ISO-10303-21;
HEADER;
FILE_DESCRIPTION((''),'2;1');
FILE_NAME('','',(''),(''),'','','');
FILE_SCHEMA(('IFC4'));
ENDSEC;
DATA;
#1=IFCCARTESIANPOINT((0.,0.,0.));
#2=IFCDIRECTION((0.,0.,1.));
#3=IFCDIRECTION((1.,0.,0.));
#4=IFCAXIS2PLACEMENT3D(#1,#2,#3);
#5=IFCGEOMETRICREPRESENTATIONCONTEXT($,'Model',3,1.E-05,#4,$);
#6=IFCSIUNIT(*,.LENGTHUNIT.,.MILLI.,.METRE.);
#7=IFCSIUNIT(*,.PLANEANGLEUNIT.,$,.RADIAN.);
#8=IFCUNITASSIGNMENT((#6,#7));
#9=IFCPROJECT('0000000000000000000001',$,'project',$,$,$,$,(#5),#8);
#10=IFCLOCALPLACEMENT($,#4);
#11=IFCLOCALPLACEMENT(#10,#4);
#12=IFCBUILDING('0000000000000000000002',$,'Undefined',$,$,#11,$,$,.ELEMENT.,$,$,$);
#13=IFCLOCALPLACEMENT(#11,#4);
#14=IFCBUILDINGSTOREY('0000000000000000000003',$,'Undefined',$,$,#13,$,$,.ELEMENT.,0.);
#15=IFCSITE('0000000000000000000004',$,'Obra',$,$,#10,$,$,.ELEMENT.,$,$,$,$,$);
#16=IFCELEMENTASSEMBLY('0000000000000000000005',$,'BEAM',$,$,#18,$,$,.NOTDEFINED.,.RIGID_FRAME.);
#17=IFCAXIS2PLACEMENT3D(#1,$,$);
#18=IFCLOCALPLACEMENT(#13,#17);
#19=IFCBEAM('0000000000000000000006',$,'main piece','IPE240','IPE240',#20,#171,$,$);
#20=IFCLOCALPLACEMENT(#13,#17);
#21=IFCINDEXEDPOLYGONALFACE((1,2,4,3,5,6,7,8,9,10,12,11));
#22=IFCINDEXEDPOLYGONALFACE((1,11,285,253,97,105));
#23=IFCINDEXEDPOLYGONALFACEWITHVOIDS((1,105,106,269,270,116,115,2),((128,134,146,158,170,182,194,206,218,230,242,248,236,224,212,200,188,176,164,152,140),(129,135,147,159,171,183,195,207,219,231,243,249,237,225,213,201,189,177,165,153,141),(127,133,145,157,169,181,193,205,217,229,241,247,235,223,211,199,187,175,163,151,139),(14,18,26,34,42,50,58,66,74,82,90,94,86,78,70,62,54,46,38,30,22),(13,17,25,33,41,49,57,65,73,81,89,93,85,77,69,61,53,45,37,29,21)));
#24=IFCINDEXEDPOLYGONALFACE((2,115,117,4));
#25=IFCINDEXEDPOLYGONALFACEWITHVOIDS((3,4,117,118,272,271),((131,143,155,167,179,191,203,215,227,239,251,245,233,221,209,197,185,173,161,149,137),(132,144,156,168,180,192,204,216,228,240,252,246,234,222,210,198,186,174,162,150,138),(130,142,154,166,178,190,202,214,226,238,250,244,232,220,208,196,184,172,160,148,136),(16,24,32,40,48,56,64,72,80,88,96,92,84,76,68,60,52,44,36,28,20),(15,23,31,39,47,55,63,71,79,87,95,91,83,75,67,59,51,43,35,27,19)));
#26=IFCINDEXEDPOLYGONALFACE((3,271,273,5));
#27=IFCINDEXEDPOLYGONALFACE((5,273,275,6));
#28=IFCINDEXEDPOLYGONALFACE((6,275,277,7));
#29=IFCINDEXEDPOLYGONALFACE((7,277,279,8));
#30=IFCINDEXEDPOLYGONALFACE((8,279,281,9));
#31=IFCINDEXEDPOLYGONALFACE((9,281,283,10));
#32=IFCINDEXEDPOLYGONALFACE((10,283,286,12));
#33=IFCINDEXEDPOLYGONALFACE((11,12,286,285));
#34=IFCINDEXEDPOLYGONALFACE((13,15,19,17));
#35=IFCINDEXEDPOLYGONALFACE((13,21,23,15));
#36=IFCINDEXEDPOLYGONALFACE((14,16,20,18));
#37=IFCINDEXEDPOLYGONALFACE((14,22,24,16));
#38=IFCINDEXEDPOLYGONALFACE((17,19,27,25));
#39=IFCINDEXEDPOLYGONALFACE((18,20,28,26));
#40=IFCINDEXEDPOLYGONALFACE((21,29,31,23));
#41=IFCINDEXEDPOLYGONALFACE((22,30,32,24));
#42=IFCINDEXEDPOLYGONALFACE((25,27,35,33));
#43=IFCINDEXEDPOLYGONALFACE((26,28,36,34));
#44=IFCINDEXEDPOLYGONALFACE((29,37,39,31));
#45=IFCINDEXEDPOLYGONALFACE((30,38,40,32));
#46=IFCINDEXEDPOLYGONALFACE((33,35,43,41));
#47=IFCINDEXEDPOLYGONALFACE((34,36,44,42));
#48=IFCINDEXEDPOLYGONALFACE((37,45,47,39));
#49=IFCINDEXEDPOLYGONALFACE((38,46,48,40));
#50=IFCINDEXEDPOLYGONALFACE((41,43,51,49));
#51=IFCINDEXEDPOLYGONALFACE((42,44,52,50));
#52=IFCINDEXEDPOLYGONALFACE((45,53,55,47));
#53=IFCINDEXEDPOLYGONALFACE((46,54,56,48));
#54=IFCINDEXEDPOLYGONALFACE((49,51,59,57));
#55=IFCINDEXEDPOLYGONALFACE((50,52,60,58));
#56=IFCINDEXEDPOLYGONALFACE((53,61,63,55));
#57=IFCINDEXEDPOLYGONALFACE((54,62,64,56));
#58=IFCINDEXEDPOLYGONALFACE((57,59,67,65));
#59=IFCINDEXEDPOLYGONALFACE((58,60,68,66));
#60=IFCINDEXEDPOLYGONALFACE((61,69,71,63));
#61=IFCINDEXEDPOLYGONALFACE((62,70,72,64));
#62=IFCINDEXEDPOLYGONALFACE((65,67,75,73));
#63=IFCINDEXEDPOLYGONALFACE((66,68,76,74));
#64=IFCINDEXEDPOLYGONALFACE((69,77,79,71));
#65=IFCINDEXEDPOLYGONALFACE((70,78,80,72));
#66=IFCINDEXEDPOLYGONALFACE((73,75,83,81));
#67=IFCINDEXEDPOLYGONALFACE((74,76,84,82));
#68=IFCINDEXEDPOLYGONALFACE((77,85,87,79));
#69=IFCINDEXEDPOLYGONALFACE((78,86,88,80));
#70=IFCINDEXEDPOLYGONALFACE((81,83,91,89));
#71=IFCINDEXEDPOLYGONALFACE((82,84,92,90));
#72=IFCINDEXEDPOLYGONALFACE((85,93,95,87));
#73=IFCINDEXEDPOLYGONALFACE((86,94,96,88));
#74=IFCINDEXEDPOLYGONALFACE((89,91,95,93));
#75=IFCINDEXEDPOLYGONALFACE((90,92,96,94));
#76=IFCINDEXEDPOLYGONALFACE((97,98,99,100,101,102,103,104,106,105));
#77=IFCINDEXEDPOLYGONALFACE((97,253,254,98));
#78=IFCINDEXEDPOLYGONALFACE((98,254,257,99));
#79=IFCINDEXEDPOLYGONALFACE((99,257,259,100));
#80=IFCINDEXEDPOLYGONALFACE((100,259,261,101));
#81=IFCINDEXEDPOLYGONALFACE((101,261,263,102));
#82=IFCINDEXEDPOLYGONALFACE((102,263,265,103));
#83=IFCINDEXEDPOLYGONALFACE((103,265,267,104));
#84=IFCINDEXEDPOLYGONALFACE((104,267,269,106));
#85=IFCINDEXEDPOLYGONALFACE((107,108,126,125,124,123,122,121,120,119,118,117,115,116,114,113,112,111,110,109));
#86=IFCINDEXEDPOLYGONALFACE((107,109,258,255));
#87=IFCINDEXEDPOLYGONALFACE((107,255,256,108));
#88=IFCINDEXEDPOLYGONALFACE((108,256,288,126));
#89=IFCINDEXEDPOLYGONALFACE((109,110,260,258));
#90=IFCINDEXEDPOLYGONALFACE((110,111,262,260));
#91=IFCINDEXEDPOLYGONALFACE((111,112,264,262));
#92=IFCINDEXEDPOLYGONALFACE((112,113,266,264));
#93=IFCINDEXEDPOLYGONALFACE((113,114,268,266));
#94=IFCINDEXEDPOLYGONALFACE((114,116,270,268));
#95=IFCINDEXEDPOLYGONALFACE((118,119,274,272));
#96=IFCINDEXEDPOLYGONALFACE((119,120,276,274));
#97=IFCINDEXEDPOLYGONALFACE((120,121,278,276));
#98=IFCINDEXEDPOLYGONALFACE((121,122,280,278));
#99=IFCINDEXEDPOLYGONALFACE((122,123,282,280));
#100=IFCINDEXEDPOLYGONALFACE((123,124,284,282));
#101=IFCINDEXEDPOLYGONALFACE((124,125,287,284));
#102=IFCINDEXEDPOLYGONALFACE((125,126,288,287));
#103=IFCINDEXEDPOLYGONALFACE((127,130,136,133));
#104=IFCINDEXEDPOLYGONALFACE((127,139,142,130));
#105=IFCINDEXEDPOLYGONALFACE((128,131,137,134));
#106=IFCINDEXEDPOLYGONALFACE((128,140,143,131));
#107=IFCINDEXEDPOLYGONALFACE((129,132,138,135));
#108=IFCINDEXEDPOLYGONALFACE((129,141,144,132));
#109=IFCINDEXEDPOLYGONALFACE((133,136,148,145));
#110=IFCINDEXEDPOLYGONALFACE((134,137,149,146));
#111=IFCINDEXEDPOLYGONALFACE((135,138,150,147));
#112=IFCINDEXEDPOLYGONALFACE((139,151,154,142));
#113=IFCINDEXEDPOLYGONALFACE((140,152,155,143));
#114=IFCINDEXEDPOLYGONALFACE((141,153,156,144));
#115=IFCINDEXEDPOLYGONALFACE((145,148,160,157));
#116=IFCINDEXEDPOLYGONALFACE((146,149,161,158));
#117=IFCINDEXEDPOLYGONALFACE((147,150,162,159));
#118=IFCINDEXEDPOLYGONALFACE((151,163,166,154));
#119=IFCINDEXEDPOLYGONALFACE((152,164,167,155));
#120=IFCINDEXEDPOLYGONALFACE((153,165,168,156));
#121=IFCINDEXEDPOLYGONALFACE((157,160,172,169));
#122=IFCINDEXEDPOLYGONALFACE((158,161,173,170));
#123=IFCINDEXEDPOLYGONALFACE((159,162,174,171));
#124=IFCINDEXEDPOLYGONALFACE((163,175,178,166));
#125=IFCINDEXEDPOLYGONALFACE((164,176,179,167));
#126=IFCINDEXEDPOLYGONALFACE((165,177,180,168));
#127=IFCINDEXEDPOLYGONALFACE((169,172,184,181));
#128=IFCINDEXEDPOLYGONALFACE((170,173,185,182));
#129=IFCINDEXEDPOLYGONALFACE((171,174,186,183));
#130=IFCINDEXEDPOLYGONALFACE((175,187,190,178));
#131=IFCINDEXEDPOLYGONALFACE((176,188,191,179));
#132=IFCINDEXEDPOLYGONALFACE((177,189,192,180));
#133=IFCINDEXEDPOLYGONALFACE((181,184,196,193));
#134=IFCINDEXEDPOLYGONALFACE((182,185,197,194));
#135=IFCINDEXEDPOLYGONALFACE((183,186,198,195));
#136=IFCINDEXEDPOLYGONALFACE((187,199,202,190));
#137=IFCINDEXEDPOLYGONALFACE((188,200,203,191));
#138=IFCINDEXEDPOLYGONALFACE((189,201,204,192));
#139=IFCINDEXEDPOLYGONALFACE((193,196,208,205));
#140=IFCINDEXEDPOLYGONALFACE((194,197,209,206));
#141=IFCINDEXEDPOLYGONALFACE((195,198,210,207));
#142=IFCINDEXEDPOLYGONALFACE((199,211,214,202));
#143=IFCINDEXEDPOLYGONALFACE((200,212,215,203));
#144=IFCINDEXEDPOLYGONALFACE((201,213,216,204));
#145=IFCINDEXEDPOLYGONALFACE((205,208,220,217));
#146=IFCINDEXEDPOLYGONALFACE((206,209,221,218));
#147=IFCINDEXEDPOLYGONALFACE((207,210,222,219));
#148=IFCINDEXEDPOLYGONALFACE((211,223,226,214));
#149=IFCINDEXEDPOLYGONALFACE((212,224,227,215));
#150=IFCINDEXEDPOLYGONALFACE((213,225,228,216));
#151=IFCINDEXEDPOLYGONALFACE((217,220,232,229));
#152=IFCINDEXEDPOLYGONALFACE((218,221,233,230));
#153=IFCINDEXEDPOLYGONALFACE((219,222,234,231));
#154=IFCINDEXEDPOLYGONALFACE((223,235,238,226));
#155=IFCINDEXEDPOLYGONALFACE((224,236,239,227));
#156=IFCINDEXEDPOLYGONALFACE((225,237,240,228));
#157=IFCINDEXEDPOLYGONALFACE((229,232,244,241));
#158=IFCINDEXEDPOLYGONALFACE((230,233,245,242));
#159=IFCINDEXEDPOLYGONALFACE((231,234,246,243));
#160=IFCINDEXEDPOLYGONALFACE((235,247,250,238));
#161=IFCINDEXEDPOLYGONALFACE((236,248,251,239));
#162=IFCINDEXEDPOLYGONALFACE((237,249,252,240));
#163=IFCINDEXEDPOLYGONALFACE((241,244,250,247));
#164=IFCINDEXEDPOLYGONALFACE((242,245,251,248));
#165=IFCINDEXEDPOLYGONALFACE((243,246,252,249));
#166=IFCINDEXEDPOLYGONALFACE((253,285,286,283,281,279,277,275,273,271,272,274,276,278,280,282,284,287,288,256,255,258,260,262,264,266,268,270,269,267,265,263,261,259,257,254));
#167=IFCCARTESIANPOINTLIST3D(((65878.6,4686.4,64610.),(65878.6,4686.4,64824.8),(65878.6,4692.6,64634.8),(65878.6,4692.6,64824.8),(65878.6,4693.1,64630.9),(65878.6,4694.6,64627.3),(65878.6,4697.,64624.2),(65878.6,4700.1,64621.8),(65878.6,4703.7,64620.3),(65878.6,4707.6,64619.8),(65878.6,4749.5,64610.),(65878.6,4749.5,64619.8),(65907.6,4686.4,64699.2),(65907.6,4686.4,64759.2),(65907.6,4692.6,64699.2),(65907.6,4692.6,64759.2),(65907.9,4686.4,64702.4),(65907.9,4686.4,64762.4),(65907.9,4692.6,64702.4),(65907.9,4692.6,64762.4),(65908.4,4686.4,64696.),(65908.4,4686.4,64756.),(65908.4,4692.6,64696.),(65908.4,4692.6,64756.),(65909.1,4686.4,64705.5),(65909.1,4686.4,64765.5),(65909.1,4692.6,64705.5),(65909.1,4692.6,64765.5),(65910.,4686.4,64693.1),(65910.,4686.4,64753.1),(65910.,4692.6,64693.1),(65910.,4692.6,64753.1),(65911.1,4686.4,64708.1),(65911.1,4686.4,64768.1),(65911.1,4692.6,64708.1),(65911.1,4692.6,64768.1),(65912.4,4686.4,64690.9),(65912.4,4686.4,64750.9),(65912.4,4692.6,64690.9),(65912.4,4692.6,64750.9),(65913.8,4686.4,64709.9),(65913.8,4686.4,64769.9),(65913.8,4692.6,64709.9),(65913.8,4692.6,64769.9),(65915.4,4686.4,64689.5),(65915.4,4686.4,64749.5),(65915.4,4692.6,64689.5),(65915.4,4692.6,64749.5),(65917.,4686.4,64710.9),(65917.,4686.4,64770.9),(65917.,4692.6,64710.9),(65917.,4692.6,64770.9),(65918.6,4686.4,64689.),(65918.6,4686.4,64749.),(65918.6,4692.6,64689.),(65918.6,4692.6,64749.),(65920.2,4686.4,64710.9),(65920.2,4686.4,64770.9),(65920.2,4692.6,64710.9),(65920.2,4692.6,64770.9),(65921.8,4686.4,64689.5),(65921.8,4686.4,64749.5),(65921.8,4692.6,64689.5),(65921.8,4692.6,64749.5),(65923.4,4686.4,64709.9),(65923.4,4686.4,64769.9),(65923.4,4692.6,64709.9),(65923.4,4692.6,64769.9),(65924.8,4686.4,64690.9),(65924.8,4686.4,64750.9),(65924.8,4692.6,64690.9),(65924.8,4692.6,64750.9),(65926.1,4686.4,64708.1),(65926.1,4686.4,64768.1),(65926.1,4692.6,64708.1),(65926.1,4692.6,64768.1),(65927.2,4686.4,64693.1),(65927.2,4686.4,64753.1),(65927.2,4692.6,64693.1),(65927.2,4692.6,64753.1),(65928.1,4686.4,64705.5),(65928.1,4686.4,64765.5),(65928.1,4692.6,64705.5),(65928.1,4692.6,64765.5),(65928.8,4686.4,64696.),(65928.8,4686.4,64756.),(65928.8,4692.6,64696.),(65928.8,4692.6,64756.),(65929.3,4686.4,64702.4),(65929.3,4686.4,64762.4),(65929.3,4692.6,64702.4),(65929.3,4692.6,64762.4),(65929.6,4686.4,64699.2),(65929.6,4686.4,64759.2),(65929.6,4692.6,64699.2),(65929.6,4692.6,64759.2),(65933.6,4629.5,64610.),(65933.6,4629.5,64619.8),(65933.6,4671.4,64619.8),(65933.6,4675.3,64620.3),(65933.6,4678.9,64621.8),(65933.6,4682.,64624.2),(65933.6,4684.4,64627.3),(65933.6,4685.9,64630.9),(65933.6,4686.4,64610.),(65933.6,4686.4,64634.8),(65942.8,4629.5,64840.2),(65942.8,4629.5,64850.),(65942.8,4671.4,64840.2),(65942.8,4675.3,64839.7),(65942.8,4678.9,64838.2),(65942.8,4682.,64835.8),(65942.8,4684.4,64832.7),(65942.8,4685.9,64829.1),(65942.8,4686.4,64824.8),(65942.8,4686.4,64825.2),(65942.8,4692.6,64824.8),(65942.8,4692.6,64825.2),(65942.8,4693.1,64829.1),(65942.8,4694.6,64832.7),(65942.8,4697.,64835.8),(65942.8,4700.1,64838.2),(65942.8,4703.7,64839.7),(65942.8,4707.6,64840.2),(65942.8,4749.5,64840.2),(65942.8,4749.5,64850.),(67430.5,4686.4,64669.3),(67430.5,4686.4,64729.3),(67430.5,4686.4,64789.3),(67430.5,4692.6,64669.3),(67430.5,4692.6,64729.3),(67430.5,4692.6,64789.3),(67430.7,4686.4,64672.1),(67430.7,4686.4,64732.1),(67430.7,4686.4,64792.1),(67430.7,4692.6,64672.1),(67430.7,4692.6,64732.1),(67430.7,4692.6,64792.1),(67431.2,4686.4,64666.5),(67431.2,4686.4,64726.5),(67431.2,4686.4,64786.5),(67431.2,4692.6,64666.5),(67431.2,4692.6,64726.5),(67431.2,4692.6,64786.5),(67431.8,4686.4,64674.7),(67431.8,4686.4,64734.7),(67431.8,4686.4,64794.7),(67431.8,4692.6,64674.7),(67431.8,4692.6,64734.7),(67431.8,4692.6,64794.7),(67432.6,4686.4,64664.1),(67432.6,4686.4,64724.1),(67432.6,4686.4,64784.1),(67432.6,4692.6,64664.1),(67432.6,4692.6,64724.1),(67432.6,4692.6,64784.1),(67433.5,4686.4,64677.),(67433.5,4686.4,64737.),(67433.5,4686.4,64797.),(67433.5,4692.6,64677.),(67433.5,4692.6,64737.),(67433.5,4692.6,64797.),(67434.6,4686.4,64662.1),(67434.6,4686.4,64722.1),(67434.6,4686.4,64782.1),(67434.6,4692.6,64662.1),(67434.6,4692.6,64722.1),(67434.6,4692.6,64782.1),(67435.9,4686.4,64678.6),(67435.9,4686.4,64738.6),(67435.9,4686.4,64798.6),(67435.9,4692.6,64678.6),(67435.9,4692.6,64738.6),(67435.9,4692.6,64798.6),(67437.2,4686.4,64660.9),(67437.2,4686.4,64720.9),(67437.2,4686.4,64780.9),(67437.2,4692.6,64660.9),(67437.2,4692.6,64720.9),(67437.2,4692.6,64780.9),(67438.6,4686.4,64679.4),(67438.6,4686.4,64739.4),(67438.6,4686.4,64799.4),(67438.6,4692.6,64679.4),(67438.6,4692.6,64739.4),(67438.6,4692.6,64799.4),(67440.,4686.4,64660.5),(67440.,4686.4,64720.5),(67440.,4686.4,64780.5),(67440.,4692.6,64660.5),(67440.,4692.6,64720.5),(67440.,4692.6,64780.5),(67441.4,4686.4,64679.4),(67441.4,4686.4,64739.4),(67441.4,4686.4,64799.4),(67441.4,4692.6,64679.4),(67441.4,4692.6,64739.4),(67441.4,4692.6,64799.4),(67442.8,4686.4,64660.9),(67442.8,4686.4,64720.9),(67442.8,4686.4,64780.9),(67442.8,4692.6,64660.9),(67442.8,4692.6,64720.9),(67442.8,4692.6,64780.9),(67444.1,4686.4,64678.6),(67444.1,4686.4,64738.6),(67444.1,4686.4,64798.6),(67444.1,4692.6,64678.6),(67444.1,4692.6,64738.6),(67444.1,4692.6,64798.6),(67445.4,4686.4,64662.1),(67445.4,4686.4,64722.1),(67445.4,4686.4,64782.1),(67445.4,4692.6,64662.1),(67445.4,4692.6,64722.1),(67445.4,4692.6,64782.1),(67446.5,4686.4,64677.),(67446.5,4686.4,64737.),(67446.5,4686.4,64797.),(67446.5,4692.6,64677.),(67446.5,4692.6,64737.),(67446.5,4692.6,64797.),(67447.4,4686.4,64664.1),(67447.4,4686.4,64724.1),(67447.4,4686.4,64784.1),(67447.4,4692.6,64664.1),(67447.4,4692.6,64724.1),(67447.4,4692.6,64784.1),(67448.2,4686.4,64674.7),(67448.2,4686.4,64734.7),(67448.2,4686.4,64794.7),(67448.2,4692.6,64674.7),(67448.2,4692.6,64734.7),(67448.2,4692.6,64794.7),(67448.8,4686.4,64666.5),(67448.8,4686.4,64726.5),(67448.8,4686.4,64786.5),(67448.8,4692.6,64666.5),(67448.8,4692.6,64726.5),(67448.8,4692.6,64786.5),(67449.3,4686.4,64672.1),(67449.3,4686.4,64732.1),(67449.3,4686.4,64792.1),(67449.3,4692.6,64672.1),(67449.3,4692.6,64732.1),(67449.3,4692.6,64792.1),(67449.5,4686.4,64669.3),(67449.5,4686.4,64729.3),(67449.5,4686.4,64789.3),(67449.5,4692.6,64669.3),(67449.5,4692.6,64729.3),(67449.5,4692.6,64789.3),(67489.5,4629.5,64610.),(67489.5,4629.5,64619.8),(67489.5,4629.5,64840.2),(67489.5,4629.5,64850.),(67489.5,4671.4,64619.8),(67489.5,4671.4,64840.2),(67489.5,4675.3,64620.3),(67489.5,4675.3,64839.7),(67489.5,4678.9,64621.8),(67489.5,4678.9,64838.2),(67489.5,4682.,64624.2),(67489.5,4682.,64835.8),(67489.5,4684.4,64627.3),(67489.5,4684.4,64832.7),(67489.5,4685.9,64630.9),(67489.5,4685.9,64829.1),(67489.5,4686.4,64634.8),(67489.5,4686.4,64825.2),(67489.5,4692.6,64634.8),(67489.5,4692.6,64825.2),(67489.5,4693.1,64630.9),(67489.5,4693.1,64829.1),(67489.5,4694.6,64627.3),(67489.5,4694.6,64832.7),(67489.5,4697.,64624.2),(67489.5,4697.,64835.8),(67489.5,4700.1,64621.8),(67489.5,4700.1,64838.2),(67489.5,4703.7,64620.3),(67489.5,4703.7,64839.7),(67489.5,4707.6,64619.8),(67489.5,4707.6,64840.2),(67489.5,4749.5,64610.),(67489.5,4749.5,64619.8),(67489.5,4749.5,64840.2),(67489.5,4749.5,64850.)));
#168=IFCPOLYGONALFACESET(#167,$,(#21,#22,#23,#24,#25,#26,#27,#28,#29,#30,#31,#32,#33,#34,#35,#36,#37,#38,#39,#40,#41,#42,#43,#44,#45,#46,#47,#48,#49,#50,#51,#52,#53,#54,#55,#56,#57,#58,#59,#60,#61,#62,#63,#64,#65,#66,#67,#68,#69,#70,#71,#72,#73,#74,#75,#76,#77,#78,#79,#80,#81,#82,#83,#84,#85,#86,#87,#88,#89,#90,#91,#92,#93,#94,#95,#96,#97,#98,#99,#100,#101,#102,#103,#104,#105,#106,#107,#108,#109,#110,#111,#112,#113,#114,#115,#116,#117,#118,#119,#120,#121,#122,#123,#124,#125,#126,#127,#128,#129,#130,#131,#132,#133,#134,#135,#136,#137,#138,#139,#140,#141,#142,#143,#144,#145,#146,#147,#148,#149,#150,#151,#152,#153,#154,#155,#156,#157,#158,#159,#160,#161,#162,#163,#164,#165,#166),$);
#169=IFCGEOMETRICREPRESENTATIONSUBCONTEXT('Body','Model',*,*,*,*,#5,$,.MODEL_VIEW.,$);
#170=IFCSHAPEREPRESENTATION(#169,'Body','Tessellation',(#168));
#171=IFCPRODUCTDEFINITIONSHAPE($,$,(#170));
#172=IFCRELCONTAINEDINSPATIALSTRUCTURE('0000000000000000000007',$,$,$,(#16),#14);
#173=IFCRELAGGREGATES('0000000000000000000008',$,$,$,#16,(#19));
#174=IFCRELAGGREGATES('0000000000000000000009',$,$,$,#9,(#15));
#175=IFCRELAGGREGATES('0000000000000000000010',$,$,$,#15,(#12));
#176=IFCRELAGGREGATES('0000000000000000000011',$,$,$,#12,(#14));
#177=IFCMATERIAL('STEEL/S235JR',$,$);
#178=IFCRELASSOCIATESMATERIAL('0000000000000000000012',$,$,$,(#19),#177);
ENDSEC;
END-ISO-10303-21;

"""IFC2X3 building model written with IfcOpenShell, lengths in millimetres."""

from ifc_helpers import new_model, si_unit, frame, origin_with_axes, origin_2d_with_axis, place, context, subcontext, project, spatial, rectangle, circle, i_section, extrude, clip, halfspace, source, transform, mapped, material, element, aggregate, save


model = new_model("IFC2X3")

# Units and contexts
model_context = context("Model", 3, precision=1e-05, world=origin_with_axes())
body_context = subcontext(model_context, "Body", "Model", "MODEL_VIEW")
ifc_project = project(units=[si_unit("LENGTHUNIT", "METRE", prefix="MILLI"), si_unit("PLANEANGLEUNIT", "RADIAN")], contexts=[model_context])

# Site, building, storey
site_placement = place(None, origin_with_axes())
site = spatial("IfcSite", under=ifc_project, at=site_placement, Name="Obra", CompositionType="ELEMENT")
building_placement = place(site_placement, origin_with_axes())
building = spatial("IfcBuilding", under=site, at=building_placement, Name="Undefined", CompositionType="ELEMENT")
storey_placement = place(building_placement, origin_with_axes())
storey = spatial("IfcBuildingStorey", under=building, at=storey_placement, Name="Undefined", CompositionType="ELEMENT", Elevation=0.0)

# Element assembly, beam, openings
assembly_1_placement = place(storey_placement, origin_with_axes())
assembly_1 = element("IfcElementAssembly", 1, at=assembly_1_placement, inside=storey, Name="BEAM", AssemblyPlace="NOTDEFINED", PredefinedType="RIGID_FRAME")
ifc_material = material(Name="STEEL/S235JR")
beam_1_placement = place(assembly_1_placement, frame((65952.4, 4689.5, 64730.0), z_axis=(0.0, 0.0, 1.0), x_axis=(1.0, 0.0, 0.0)))
beam_1 = element("IfcBeam", 2, at=beam_1_placement, material=ifc_material, Name="main piece", Description="IPE240", ObjectType="IPE240", context=body_context, shape_type="Clipping", body=[
    clip(clip(extrude(i_section(OverallWidth=120.0, OverallDepth=240.0, WebThickness=6.2, FlangeThickness=9.8, FilletRadius=15.0, at=origin_2d_with_axis()), frame((1754.5, 0.0, 0.0), z_axis=(-1.0, 0.0, 0.0), x_axis=(0.0, -1.0, 0.0)), (0.0, 0.0, 1.0), 1828.3), halfspace(frame((1537.1, -60.0, -120.0), z_axis=(1.0, 0.000019, 0.0), x_axis=(0.0, 0.0, 1.0)), False)), halfspace(frame((-73.8, 0.0, -220.0), z_axis=(1.0, 0.0, 0.0), x_axis=(0.0, -1.0, 0.0)), True)),
])
opening_1_placement = place(assembly_1_placement, frame((65952.4, 4689.5, 64730.0), z_axis=(0.0, 0.0, 1.0), x_axis=(1.0, 0.0, 0.0)))
element("IfcOpeningElement", 3, at=opening_1_placement, cuts=beam_1, ObjectType="Recess", context=body_context, shape_type="SweptSolid", body=[
    extrude(rectangle(XDim=65.0, YDim=300.0, at=origin_2d_with_axis()), frame((-51.3, -153.1, 109.8), z_axis=(0.0, 0.0, -1.0), x_axis=(1.0, 0.0, 0.0)), (0.0, 0.0, 1.0), 249.6),
])
opening_2_placement = place(assembly_1_placement, frame((65952.4, 4689.5, 64730.0), z_axis=(0.0, 0.0, 1.0), x_axis=(1.0, 0.0, 0.0)))
element("IfcOpeningElement", 4, at=opening_2_placement, cuts=beam_1, ObjectType="Recess", context=body_context, shape_type="SweptSolid", body=[
    extrude(rectangle(XDim=26.2, YDim=76.2, at=origin_2d_with_axis()), frame((-47.7, -61.0, 107.9), z_axis=(0.0, 1.0, 0.0), x_axis=(0.0, 0.0, -1.0)), (0.0, 0.0, 1.0), 122.0),
])
shared_shape_1 = source(origin_with_axes(), body_context, "Body", "SweptSolid", [
    extrude(circle(Radius=11.0, at=origin_2d_with_axis()), frame((0.0, -3.2, 0.0), z_axis=(0.0, 1.0, 0.0), x_axis=(1.0, 0.0, 0.0)), (0.0, 0.0, 1.0), 6.4),
])
opening_3_placement = place(assembly_1_placement, frame((65878.6, 4689.5, 64850.0), z_axis=(1.0, 0.0, 0.0), x_axis=(0.0, 0.0, -1.0)))
element("IfcOpeningElement", 5, at=opening_3_placement, cuts=beam_1, ObjectType="Opening", context=body_context, shape_type="MappedRepresentation", body=[
    mapped(shared_shape_1, transform((90.0, 0.0, 40.0))),
    mapped(shared_shape_1, transform((150.0, 0.0, 40.0))),
])
shared_shape_2 = source(origin_with_axes(), body_context, "Body", "SweptSolid", [
    extrude(circle(Radius=9.5, at=origin_2d_with_axis()), frame((0.0, -3.2, 0.0), z_axis=(0.0, 1.0, 0.0), x_axis=(1.0, 0.0, 0.0)), (0.0, 0.0, 1.0), 6.4),
])
opening_4_placement = place(assembly_1_placement, frame((67490.0, 4689.5, 64850.0), z_axis=(-1.0, 0.0, 0.0), x_axis=(0.0, 0.0, -1.0)))
element("IfcOpeningElement", 6, at=opening_4_placement, cuts=beam_1, ObjectType="Opening", context=body_context, shape_type="MappedRepresentation", body=[
    mapped(shared_shape_2, transform((60.0, 0.0, 50.0))),
    mapped(shared_shape_2, transform((120.0, 0.0, 50.0))),
    mapped(shared_shape_2, transform((180.0, 0.0, 50.0))),
])
aggregate(assembly_1, [beam_1])

save(model, "model.ifc")
